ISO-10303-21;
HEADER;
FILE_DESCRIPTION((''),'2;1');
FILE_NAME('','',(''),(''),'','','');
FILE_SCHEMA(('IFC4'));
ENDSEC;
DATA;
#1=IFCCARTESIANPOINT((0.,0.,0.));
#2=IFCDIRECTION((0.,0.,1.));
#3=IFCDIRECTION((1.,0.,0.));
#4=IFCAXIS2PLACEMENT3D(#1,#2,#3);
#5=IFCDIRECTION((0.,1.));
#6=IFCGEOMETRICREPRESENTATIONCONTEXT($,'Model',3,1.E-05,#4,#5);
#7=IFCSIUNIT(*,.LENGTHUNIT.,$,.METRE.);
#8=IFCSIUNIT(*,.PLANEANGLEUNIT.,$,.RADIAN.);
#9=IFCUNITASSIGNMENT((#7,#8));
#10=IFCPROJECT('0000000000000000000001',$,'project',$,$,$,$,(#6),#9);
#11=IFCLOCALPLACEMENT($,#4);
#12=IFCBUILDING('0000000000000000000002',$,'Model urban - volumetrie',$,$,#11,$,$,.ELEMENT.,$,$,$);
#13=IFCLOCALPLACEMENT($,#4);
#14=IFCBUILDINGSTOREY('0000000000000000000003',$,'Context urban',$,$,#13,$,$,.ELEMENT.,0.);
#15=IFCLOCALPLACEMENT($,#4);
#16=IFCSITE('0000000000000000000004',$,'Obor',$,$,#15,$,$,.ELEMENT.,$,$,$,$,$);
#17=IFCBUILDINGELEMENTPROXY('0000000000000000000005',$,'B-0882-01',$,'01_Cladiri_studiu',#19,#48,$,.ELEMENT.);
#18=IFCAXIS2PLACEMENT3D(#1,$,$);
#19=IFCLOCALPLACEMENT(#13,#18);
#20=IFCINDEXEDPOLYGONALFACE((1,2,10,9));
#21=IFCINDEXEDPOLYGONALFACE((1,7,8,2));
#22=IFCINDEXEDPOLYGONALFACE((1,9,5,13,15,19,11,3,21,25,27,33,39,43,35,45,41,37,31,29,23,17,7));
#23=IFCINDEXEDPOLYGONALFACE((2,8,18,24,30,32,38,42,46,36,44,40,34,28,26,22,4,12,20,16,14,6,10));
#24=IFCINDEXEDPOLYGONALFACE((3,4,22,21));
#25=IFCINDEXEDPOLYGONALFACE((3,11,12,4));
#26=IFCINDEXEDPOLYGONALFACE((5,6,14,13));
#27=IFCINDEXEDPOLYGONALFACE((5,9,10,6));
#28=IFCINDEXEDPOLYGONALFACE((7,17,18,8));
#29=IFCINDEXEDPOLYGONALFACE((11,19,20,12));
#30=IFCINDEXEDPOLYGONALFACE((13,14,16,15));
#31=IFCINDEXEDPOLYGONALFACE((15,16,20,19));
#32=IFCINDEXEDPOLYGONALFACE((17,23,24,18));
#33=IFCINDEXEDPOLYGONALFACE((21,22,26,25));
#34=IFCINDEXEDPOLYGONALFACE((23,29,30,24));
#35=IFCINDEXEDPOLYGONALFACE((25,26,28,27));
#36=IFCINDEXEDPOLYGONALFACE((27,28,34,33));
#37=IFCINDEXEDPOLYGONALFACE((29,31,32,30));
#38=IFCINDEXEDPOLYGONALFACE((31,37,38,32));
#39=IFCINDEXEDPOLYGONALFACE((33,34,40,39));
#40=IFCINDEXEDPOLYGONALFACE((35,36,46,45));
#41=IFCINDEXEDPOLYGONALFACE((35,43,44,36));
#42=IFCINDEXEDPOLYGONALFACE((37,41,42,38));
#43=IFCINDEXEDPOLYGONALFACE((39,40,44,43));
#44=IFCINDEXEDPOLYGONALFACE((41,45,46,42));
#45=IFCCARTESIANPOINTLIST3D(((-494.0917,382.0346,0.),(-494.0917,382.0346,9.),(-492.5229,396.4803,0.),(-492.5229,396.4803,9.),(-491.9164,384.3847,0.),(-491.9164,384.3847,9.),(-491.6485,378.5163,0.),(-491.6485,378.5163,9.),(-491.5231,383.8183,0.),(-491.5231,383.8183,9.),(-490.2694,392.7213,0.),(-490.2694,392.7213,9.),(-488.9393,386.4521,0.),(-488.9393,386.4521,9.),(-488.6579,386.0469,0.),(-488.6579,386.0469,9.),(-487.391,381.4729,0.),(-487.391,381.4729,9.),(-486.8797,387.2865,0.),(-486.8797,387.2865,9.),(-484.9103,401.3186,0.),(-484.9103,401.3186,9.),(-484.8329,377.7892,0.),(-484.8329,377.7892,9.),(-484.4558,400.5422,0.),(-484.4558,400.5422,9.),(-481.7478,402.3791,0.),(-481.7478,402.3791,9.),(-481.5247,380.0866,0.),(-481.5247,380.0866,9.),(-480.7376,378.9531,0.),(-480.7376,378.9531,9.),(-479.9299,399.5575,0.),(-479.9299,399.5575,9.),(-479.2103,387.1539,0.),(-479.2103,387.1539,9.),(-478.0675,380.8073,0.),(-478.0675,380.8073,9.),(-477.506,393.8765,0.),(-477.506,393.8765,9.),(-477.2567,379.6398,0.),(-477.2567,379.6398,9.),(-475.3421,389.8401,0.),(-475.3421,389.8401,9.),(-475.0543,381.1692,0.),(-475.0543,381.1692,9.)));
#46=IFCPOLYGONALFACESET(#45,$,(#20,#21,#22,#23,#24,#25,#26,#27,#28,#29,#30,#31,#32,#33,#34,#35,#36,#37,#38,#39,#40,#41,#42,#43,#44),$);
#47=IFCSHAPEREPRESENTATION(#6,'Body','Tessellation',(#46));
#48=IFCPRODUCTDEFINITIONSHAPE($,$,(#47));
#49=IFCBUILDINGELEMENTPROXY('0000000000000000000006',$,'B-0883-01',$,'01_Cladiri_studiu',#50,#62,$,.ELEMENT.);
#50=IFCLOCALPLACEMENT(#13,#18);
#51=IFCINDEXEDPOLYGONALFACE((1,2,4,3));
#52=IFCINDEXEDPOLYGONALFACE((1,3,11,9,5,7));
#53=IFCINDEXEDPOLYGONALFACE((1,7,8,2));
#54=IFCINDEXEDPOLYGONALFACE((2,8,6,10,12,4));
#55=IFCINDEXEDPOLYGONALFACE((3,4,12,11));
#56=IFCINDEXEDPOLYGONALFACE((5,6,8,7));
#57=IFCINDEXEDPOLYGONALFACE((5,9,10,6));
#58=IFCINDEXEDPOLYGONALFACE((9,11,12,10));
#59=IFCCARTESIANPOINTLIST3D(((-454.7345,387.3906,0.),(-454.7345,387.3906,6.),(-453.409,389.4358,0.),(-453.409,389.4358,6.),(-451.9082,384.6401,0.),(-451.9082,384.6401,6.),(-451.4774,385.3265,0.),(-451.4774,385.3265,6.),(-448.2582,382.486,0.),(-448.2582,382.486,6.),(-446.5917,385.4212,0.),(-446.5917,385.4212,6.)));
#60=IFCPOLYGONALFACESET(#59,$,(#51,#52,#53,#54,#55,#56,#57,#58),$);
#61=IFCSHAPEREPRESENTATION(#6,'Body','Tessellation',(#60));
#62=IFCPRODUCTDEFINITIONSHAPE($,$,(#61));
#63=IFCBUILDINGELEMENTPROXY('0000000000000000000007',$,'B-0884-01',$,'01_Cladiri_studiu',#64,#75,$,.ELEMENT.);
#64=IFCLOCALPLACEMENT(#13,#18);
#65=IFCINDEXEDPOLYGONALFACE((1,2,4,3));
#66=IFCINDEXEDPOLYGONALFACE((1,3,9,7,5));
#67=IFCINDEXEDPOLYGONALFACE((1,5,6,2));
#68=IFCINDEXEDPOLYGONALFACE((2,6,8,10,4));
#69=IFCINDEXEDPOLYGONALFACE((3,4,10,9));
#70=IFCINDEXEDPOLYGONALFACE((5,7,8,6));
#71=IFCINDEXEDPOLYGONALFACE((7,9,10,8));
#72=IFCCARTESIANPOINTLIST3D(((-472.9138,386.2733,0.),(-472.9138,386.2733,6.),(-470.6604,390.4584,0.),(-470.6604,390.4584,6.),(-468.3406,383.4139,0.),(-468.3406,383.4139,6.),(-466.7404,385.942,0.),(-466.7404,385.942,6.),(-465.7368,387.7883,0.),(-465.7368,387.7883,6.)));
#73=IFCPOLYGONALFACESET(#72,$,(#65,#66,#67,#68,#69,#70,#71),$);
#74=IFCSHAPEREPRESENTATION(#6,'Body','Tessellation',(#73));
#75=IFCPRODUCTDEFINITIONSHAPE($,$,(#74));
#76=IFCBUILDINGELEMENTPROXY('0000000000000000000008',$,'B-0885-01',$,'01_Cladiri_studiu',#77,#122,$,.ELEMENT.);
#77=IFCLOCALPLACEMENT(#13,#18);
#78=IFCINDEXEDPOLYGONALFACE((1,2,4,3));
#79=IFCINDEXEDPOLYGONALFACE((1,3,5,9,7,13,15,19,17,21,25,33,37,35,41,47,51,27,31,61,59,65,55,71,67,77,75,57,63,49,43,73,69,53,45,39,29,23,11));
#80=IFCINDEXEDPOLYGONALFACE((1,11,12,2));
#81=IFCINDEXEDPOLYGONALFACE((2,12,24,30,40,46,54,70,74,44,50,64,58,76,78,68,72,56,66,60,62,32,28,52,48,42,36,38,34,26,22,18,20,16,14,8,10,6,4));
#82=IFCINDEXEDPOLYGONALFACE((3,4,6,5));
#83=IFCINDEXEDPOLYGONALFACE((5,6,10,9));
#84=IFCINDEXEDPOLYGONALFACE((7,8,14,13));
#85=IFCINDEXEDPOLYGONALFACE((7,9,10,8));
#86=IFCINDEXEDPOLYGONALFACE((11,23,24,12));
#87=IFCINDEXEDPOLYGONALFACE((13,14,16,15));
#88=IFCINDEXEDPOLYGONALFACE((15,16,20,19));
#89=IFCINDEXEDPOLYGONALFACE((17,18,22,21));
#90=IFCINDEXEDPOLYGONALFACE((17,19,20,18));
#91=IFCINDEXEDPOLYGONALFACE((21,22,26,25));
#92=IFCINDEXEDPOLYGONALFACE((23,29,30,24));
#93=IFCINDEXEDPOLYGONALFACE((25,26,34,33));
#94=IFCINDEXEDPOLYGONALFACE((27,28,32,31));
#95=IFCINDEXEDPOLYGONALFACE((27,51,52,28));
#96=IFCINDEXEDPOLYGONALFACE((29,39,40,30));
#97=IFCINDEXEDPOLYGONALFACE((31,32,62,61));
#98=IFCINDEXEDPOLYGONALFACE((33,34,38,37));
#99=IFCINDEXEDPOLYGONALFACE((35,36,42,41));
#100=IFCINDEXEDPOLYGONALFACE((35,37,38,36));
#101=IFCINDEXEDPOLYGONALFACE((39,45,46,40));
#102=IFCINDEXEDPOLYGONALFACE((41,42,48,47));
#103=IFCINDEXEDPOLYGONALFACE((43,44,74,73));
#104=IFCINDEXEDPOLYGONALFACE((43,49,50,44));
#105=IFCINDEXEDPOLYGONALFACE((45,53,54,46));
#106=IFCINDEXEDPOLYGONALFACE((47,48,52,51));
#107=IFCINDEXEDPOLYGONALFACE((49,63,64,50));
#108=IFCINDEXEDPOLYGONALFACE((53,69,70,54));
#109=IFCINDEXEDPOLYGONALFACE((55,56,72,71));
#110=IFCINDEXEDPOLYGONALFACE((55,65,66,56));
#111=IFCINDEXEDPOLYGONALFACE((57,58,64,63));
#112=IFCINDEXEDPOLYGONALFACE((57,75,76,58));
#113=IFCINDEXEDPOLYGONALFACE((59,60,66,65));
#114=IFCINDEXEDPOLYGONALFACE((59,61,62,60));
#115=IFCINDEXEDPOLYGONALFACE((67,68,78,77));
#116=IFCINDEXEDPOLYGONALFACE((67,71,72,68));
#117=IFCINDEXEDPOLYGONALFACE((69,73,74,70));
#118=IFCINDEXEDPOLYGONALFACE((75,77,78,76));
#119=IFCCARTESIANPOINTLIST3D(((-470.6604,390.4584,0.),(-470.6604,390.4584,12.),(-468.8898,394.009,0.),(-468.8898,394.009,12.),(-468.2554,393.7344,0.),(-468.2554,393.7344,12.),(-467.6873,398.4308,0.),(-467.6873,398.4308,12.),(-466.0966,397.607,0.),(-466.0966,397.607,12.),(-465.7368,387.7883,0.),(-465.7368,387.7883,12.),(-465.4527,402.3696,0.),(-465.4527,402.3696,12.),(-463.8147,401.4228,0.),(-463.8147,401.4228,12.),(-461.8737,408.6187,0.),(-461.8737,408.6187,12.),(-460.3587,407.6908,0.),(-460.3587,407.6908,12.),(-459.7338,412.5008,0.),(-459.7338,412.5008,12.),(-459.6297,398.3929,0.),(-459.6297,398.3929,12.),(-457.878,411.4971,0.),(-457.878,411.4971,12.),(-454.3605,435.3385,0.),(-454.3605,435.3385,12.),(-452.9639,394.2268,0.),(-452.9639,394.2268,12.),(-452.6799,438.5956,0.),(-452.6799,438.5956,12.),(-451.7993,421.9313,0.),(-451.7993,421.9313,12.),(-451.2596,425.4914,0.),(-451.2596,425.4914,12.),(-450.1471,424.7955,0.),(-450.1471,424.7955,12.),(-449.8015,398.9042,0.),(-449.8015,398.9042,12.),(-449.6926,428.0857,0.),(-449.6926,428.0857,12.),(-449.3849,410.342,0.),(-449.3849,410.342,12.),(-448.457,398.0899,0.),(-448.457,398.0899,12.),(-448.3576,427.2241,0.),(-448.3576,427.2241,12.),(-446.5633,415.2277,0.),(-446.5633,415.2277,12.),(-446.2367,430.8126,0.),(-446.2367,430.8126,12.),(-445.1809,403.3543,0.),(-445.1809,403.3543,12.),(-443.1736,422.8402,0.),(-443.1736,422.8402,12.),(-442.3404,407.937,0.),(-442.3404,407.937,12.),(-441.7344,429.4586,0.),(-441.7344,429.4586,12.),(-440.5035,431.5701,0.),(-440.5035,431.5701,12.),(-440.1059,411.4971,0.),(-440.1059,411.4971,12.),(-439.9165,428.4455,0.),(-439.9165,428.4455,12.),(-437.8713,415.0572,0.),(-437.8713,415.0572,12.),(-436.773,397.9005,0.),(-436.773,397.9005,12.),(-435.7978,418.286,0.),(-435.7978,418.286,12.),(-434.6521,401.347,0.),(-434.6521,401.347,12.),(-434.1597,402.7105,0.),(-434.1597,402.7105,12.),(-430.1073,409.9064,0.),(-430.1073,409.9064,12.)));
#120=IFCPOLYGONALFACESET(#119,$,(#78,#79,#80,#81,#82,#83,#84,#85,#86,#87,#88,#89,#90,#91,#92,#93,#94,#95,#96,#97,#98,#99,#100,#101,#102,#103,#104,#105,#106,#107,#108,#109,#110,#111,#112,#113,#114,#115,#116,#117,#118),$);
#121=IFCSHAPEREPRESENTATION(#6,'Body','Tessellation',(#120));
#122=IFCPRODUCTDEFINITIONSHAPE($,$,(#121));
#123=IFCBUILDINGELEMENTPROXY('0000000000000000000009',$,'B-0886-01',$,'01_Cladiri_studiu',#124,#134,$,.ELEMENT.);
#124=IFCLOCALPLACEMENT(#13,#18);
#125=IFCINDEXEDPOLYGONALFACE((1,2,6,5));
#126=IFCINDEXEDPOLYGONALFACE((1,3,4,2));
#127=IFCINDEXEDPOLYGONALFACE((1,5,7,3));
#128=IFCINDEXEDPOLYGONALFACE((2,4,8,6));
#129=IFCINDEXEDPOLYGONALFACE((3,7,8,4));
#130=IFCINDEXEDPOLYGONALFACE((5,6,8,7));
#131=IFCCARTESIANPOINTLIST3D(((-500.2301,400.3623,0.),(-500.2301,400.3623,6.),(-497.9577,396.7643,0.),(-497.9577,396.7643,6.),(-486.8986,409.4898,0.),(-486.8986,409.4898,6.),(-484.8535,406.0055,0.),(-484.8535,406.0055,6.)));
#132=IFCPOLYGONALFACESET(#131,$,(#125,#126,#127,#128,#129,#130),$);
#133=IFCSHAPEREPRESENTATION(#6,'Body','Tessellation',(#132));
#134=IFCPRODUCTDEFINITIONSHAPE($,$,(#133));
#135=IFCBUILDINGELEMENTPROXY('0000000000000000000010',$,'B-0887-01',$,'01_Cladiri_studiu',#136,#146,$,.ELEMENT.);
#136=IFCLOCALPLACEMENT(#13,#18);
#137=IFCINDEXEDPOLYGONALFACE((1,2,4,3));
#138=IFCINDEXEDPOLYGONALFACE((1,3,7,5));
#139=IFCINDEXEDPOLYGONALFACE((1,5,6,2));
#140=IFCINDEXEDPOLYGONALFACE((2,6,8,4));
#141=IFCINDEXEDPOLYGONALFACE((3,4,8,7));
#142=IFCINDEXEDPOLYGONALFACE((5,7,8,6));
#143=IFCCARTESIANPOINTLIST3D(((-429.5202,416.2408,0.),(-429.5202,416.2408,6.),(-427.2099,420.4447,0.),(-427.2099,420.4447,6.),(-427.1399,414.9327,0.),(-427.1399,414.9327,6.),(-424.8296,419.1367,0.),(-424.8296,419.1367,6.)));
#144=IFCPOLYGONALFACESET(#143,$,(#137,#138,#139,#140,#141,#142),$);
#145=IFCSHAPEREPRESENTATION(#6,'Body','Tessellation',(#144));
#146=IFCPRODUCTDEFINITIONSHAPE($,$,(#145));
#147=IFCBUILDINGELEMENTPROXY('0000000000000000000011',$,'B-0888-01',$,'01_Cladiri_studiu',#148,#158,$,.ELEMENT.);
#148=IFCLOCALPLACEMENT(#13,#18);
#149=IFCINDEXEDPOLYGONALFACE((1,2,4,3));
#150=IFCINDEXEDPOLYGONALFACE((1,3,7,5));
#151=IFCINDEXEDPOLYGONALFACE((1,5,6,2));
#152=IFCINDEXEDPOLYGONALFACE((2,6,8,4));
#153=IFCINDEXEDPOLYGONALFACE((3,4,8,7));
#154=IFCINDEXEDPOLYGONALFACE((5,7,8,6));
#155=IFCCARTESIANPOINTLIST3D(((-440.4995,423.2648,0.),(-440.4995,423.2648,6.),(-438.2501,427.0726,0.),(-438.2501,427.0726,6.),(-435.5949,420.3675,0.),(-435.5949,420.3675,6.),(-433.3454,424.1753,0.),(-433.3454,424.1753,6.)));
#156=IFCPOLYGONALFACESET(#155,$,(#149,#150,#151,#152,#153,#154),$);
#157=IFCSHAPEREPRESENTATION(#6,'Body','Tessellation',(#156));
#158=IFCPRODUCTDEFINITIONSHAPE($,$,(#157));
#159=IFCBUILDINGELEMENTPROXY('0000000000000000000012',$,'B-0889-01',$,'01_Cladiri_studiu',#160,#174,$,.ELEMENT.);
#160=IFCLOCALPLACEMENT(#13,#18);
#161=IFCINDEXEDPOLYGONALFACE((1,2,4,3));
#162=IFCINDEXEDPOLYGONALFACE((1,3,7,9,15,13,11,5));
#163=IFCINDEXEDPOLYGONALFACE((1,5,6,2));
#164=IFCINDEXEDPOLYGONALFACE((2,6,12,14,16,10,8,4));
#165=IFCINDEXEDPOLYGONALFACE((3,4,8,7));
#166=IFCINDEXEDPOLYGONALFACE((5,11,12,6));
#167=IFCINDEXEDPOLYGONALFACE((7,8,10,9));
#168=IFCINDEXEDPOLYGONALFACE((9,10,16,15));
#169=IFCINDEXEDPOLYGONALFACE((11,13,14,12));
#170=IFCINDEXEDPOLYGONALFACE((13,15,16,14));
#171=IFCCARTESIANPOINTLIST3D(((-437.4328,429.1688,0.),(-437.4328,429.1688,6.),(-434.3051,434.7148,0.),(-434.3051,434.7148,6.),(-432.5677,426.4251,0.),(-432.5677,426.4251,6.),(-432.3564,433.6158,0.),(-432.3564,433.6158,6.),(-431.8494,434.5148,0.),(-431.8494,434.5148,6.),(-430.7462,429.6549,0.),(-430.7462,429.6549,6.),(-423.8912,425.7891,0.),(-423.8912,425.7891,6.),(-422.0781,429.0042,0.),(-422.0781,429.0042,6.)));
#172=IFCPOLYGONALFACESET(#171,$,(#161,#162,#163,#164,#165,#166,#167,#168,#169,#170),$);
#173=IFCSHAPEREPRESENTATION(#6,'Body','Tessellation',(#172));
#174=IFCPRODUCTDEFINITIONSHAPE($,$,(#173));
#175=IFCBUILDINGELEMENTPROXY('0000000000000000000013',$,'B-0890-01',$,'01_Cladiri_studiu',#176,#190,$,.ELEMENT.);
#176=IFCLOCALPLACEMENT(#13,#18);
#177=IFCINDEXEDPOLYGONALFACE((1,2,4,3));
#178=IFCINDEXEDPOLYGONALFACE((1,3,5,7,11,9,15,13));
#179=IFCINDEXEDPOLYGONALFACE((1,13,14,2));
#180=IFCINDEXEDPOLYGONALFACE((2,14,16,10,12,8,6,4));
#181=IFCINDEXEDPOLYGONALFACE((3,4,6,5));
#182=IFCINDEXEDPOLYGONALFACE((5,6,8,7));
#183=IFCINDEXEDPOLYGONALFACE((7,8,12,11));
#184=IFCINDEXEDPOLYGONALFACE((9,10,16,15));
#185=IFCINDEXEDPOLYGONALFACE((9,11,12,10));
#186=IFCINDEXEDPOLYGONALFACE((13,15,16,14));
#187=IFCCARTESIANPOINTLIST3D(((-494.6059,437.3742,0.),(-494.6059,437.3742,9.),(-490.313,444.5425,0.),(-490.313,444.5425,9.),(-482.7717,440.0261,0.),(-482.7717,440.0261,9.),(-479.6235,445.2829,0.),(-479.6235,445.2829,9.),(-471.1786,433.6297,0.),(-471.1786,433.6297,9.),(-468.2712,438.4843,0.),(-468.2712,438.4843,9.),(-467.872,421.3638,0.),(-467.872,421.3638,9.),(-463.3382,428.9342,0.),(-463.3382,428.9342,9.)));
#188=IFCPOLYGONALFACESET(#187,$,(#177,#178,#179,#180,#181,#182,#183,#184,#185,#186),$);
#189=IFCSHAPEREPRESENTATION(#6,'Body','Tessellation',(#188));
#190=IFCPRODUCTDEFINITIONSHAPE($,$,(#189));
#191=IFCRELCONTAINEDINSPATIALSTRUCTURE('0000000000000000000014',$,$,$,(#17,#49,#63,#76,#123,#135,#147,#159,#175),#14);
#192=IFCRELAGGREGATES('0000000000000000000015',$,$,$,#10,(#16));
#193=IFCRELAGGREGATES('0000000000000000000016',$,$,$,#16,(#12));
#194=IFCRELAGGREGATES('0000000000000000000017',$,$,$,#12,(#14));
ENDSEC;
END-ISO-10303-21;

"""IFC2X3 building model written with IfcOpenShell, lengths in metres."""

from ifc_helpers import new_model, si_unit, direction, origin_with_axes, place, context, project, spatial, polyline, outline, extrude, element, save


model = new_model("IFC2X3")

# Units and contexts
model_context = context("Model", 3, precision=1e-05, world=origin_with_axes(), true_north=direction((0.0, 1.0)))
ifc_project = project(units=[si_unit("LENGTHUNIT", "METRE"), si_unit("PLANEANGLEUNIT", "RADIAN")], contexts=[model_context])

# Site, building, storey
site_placement = place(None, origin_with_axes())
site = spatial("IfcSite", under=ifc_project, at=site_placement, Name="Obor", CompositionType="ELEMENT")
building_placement = place(None, origin_with_axes())
building = spatial("IfcBuilding", under=site, at=building_placement, Name="Model urban - volumetrie", CompositionType="ELEMENT")
storey_placement = place(None, origin_with_axes())
storey = spatial("IfcBuildingStorey", under=building, at=storey_placement, Name="Context urban", CompositionType="ELEMENT", Elevation=0.0)

# Building element proxies
proxy_1_placement = place(None, origin_with_axes())
element("IfcBuildingElementProxy", 1, at=proxy_1_placement, inside=storey, Name="B-0882-01", ObjectType="01_Cladiri_studiu", CompositionType="ELEMENT", context=model_context, shape_type="SweptSolid", body=[
    extrude(outline(polyline([(-488.6579, 386.0469), (-488.9393, 386.4521), (-491.9164, 384.3847), (-491.5231, 383.8183), (-494.0917, 382.0346), (-491.6485, 378.5163), (-487.391, 381.4729), (-484.8329, 377.7892), (-481.5247, 380.0866), (-480.7376, 378.9531), (-478.0675, 380.8073), (-477.2567, 379.6398), (-475.0543, 381.1692), (-479.2103, 387.1539), (-475.3421, 389.8401), (-477.506, 393.8765), (-479.9299, 399.5575), (-481.7478, 402.3791), (-484.4558, 400.5422), (-484.9103, 401.3186), (-492.5229, 396.4803), (-490.2694, 392.7213), (-486.8797, 387.2865), (-488.6579, 386.0469)])), origin_with_axes(), (0.0, 0.0, 1.0), 9.0),
])
proxy_2_placement = place(None, origin_with_axes())
element("IfcBuildingElementProxy", 2, at=proxy_2_placement, inside=storey, Name="B-0883-01", ObjectType="01_Cladiri_studiu", CompositionType="ELEMENT", context=model_context, shape_type="SweptSolid", body=[
    extrude(outline(polyline([(-448.2582, 382.486), (-446.5917, 385.4212), (-453.409, 389.4358), (-454.7345, 387.3906), (-451.4774, 385.3265), (-451.9082, 384.6401), (-448.2582, 382.486)])), origin_with_axes(), (0.0, 0.0, 1.0), 6.0),
])
proxy_3_placement = place(None, origin_with_axes())
element("IfcBuildingElementProxy", 3, at=proxy_3_placement, inside=storey, Name="B-0884-01", ObjectType="01_Cladiri_studiu", CompositionType="ELEMENT", context=model_context, shape_type="SweptSolid", body=[
    extrude(outline(polyline([(-468.3406, 383.4139), (-466.7404, 385.942), (-465.7368, 387.7883), (-470.6604, 390.4584), (-472.9138, 386.2733), (-468.3406, 383.4139)])), origin_with_axes(), (0.0, 0.0, 1.0), 6.0),
])
proxy_4_placement = place(None, origin_with_axes())
element("IfcBuildingElementProxy", 4, at=proxy_4_placement, inside=storey, Name="B-0885-01", ObjectType="01_Cladiri_studiu", CompositionType="ELEMENT", context=model_context, shape_type="SweptSolid", body=[
    extrude(outline(polyline([(-459.7338, 412.5008), (-461.8737, 408.6187), (-460.3587, 407.6908), (-463.8147, 401.4228), (-465.4527, 402.3696), (-467.6873, 398.4308), (-466.0966, 397.607), (-468.2554, 393.7344), (-468.8898, 394.009), (-470.6604, 390.4584), (-465.7368, 387.7883), (-459.6297, 398.3929), (-452.9639, 394.2268), (-449.8015, 398.9042), (-448.457, 398.0899), (-445.1809, 403.3543), (-436.773, 397.9005), (-434.6521, 401.347), (-449.3849, 410.342), (-446.5633, 415.2277), (-440.1059, 411.4971), (-442.3404, 407.937), (-434.1597, 402.7105), (-430.1073, 409.9064), (-437.8713, 415.0572), (-435.7978, 418.286), (-443.1736, 422.8402), (-439.9165, 428.4455), (-441.7344, 429.4586), (-440.5035, 431.5701), (-452.6799, 438.5956), (-454.3605, 435.3385), (-446.2367, 430.8126), (-448.3576, 427.2241), (-449.6926, 428.0857), (-451.2596, 425.4914), (-450.1471, 424.7955), (-451.7993, 421.9313), (-457.878, 411.4971), (-459.7338, 412.5008)]), holes=[polyline([(-446.6201, 421.0413), (-447.5575, 419.4695), (-451.9035, 411.8759), (-447.5575, 419.4695), (-446.6201, 421.0413)]), polyline([(-456.6471, 403.6289), (-451.9035, 411.8759), (-456.6471, 403.6289), (-455.0068, 402.4968), (-456.6471, 403.6289)])]), origin_with_axes(), (0.0, 0.0, 1.0), 12.0),
])
proxy_5_placement = place(None, origin_with_axes())
element("IfcBuildingElementProxy", 5, at=proxy_5_placement, inside=storey, Name="B-0886-01", ObjectType="01_Cladiri_studiu", CompositionType="ELEMENT", context=model_context, shape_type="SweptSolid", body=[
    extrude(outline(polyline([(-484.8535, 406.0055), (-486.8986, 409.4898), (-500.2301, 400.3623), (-497.9577, 396.7643), (-484.8535, 406.0055)])), origin_with_axes(), (0.0, 0.0, 1.0), 6.0),
])
proxy_6_placement = place(None, origin_with_axes())
element("IfcBuildingElementProxy", 6, at=proxy_6_placement, inside=storey, Name="B-0887-01", ObjectType="01_Cladiri_studiu", CompositionType="ELEMENT", context=model_context, shape_type="SweptSolid", body=[
    extrude(outline(polyline([(-427.1399, 414.9327), (-424.8296, 419.1367), (-427.2099, 420.4447), (-429.5202, 416.2408), (-427.1399, 414.9327)])), origin_with_axes(), (0.0, 0.0, 1.0), 6.0),
])
proxy_7_placement = place(None, origin_with_axes())
element("IfcBuildingElementProxy", 7, at=proxy_7_placement, inside=storey, Name="B-0888-01", ObjectType="01_Cladiri_studiu", CompositionType="ELEMENT", context=model_context, shape_type="SweptSolid", body=[
    extrude(outline(polyline([(-435.5949, 420.3675), (-433.3454, 424.1753), (-438.2501, 427.0726), (-440.4995, 423.2648), (-435.5949, 420.3675)])), origin_with_axes(), (0.0, 0.0, 1.0), 6.0),
])
proxy_8_placement = place(None, origin_with_axes())
element("IfcBuildingElementProxy", 8, at=proxy_8_placement, inside=storey, Name="B-0889-01", ObjectType="01_Cladiri_studiu", CompositionType="ELEMENT", context=model_context, shape_type="SweptSolid", body=[
    extrude(outline(polyline([(-432.3564, 433.6158), (-434.3051, 434.7148), (-437.4328, 429.1688), (-432.5677, 426.4251), (-430.7462, 429.6549), (-423.8912, 425.7891), (-422.0781, 429.0042), (-431.8494, 434.5148), (-432.3564, 433.6158)])), origin_with_axes(), (0.0, 0.0, 1.0), 6.0),
])
proxy_9_placement = place(None, origin_with_axes())
element("IfcBuildingElementProxy", 9, at=proxy_9_placement, inside=storey, Name="B-0890-01", ObjectType="01_Cladiri_studiu", CompositionType="ELEMENT", context=model_context, shape_type="SweptSolid", body=[
    extrude(outline(polyline([(-471.1786, 433.6297), (-468.2712, 438.4843), (-479.6235, 445.2829), (-482.7717, 440.0261), (-490.313, 444.5425), (-494.6059, 437.3742), (-467.872, 421.3638), (-463.3382, 428.9342), (-471.1786, 433.6297)])), origin_with_axes(), (0.0, 0.0, 1.0), 9.0),
])

save(model, "model.ifc")
